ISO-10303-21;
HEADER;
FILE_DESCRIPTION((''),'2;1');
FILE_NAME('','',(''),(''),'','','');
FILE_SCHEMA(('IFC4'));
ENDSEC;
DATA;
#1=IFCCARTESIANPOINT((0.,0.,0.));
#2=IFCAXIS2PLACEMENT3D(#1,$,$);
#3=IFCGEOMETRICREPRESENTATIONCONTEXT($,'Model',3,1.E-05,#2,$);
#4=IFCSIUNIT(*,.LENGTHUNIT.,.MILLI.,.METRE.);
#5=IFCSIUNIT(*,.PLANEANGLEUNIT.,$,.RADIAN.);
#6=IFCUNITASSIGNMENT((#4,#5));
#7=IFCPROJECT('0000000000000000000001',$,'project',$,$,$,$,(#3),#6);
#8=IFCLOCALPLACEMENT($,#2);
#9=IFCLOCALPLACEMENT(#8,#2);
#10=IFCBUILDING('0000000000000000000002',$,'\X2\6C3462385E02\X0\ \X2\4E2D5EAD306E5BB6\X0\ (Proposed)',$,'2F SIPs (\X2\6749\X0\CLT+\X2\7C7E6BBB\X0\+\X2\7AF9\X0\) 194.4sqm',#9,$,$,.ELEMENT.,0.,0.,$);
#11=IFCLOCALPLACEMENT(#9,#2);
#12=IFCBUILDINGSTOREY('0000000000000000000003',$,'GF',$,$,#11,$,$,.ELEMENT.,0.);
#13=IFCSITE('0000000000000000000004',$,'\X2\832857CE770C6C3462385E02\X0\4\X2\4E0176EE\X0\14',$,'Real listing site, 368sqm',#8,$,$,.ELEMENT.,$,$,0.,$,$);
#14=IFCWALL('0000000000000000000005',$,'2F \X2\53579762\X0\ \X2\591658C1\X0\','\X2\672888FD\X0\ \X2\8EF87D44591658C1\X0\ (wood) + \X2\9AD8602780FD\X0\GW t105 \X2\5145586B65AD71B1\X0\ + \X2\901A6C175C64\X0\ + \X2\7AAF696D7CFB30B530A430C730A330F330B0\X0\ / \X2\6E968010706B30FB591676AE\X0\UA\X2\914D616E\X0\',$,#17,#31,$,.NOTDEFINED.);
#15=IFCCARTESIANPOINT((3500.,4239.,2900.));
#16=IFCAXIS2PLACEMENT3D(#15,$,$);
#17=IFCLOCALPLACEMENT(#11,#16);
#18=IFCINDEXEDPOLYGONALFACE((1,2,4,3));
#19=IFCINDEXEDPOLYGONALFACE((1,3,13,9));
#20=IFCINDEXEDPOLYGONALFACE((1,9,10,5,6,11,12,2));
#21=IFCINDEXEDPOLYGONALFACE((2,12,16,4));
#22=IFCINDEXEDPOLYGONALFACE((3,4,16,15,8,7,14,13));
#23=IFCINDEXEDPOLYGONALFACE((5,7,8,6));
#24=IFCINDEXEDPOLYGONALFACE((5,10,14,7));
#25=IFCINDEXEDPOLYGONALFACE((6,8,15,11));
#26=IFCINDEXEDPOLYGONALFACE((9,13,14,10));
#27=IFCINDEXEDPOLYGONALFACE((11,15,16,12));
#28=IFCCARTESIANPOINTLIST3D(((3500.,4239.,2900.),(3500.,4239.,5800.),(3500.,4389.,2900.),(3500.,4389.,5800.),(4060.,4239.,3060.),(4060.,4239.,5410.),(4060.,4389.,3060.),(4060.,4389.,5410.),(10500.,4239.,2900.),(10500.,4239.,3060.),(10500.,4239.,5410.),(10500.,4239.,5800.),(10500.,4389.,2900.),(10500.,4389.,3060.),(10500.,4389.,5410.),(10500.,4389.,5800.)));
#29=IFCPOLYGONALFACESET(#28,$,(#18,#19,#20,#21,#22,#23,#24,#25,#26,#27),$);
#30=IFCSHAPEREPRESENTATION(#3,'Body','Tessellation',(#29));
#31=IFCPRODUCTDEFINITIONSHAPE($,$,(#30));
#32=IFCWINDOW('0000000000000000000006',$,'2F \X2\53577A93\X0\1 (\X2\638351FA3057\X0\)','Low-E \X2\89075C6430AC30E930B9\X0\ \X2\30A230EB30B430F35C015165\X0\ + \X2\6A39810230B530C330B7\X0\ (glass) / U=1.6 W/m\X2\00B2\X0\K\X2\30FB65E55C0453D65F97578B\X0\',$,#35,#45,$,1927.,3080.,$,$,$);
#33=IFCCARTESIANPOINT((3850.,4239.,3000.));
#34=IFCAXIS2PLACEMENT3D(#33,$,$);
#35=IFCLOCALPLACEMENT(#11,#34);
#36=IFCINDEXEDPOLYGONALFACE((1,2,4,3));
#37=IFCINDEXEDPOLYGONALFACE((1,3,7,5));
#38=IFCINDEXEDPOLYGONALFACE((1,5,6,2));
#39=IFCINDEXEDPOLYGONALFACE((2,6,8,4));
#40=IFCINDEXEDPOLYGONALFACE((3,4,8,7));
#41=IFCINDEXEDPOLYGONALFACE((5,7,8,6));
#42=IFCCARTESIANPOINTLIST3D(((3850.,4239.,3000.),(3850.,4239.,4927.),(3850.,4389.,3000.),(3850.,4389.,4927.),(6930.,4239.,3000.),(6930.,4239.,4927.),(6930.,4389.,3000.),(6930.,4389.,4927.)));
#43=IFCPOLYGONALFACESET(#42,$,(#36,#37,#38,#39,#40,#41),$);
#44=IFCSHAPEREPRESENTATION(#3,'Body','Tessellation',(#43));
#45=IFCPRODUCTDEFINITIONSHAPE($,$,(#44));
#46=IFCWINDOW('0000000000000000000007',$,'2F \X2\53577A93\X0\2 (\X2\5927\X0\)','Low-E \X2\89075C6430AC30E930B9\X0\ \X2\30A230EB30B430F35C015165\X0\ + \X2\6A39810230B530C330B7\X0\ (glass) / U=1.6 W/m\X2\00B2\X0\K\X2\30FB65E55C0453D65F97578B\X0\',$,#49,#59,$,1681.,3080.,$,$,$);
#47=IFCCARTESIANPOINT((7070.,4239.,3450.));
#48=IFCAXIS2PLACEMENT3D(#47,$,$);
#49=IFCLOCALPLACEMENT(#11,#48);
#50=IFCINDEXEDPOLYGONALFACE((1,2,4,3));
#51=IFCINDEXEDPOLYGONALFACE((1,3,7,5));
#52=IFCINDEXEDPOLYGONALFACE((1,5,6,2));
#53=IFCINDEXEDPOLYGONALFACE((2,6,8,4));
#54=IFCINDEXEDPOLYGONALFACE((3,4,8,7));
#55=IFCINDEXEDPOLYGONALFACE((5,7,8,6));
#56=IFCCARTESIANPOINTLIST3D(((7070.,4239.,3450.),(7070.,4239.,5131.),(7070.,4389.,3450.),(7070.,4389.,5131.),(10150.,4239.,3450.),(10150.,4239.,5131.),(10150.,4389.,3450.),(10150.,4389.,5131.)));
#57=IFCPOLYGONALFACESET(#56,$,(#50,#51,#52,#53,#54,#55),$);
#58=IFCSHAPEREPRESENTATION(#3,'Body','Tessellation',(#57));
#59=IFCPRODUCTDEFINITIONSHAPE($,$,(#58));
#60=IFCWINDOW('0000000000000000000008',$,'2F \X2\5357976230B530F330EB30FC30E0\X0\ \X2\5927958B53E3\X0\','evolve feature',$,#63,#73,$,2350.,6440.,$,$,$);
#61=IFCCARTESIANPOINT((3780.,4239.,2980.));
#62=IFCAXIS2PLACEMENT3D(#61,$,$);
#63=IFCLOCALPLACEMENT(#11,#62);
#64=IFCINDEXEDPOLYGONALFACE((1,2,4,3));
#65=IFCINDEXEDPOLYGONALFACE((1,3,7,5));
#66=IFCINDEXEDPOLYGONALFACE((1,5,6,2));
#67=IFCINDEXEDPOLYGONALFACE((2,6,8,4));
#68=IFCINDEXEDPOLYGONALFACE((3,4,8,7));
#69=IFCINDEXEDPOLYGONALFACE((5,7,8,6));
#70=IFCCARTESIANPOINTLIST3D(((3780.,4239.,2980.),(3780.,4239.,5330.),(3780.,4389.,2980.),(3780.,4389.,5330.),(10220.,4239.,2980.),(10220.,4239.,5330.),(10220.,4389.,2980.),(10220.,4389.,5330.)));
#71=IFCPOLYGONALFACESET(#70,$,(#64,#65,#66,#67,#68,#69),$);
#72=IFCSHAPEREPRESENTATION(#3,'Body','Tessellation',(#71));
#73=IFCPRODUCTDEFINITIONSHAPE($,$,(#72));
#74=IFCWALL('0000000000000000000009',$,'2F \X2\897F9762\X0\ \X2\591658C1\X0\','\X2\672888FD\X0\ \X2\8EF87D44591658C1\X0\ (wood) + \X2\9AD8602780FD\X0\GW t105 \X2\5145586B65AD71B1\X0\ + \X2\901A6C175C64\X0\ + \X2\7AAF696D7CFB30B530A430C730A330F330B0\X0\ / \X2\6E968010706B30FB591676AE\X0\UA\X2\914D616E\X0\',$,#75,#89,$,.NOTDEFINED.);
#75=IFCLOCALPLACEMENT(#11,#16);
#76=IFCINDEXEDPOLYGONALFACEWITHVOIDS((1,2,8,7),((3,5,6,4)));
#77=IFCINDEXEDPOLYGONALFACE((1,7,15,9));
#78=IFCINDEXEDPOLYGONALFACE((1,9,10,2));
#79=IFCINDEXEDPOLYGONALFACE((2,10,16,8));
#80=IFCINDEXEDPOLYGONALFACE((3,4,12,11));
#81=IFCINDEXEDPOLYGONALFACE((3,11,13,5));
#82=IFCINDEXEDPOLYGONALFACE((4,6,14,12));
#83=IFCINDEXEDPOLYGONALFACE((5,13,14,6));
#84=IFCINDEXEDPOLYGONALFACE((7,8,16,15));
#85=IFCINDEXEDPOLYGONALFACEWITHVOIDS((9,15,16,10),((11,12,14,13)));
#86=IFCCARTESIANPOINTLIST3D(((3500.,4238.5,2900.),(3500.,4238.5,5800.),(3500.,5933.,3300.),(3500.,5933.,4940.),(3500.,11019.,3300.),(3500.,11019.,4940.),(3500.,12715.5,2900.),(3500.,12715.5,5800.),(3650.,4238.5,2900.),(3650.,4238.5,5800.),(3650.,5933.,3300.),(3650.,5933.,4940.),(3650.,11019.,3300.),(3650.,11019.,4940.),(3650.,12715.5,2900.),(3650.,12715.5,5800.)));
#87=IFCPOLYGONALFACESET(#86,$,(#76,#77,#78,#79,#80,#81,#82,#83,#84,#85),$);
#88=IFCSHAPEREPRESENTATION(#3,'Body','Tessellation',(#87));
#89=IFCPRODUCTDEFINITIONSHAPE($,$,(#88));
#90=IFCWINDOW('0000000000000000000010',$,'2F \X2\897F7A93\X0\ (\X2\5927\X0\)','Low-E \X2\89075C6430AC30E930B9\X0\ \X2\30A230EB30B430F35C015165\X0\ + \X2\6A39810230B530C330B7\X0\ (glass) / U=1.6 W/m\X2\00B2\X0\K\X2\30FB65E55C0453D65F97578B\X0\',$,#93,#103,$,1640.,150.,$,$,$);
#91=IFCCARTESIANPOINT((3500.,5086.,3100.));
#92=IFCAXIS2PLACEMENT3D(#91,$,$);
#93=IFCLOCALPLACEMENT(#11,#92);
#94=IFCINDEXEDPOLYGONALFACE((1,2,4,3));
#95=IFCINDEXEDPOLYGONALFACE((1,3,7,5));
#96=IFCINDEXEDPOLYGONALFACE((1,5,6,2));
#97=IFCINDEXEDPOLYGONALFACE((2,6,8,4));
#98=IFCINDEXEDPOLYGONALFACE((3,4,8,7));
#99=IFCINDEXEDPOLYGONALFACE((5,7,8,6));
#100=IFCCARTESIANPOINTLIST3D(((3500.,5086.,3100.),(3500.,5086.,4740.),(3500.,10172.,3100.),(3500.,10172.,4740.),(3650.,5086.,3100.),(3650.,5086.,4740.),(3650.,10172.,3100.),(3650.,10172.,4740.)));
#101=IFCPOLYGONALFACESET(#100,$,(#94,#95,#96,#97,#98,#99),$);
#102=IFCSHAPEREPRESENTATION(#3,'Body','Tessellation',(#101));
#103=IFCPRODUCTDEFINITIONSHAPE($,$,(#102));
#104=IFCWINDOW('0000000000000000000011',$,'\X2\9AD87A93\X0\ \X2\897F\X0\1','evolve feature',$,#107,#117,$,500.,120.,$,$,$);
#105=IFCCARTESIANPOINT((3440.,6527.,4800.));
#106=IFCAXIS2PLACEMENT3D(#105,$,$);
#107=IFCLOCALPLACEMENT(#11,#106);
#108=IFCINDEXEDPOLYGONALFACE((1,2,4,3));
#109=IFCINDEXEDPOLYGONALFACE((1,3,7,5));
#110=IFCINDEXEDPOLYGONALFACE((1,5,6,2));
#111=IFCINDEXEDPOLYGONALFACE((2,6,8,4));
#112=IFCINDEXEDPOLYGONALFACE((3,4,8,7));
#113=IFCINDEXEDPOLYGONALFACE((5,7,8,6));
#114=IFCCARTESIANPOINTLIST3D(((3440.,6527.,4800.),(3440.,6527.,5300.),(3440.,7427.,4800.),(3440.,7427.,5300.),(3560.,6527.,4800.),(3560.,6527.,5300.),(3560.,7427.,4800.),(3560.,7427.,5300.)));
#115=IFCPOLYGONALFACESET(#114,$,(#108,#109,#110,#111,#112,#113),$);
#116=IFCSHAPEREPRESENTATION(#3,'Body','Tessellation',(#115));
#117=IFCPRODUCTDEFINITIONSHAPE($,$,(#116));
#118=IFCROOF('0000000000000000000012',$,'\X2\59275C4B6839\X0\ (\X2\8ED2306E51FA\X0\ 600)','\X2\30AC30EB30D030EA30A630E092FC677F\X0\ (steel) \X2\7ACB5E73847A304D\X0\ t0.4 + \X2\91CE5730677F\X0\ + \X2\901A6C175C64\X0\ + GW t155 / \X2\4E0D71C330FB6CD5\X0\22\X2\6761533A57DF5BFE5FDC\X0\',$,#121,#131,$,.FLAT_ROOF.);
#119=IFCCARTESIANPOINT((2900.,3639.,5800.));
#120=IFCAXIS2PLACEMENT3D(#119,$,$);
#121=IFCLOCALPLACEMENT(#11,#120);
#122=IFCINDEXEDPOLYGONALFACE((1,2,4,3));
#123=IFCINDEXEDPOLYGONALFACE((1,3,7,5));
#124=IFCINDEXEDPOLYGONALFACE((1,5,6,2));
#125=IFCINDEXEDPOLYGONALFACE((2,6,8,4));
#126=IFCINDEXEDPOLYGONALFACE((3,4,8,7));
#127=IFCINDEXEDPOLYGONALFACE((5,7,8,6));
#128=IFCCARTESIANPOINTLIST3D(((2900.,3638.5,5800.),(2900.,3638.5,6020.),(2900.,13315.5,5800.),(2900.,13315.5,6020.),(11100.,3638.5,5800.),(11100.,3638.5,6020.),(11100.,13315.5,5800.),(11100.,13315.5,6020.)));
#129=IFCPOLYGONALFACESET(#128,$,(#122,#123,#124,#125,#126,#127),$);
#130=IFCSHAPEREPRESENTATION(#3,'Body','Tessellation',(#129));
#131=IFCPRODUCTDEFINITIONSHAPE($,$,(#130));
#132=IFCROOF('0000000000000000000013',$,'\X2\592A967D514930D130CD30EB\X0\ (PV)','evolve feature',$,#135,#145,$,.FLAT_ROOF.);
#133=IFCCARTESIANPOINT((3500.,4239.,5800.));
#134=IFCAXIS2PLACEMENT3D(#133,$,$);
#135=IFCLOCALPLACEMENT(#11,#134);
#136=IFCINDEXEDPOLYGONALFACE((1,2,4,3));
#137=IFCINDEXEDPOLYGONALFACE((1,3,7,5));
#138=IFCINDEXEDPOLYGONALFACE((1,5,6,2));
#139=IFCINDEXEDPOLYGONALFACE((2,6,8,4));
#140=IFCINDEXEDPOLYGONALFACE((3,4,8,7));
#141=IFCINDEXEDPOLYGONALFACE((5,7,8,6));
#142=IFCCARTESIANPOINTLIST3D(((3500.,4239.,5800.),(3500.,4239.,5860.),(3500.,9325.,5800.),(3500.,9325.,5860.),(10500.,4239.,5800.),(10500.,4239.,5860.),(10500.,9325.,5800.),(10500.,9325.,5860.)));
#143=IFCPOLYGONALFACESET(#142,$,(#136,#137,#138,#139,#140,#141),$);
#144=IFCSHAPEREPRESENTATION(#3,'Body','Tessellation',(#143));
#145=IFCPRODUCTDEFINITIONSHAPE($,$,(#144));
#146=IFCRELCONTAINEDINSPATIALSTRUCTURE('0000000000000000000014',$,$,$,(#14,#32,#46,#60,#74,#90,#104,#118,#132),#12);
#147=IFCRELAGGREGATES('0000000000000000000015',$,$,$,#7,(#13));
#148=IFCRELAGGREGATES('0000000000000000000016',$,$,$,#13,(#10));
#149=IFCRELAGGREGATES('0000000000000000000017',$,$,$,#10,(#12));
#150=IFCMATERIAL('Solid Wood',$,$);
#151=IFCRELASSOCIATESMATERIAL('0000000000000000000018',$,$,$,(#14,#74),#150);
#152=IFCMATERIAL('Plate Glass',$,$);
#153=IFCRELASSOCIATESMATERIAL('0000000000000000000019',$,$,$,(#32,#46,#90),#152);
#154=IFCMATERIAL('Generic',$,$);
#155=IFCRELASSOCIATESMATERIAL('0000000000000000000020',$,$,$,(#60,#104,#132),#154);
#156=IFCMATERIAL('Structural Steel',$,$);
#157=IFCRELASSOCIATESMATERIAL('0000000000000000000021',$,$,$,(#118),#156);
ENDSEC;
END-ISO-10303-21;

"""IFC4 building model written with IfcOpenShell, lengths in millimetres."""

from ifc_helpers import new_model, si_unit, frame, frame_2d, origin, place, context, project, spatial, rectangle, extrude, material, element, fill, save


model = new_model("IFC4")

# Units and contexts
model_context = context("Model", 3, precision=1e-05, world=origin())
ifc_project = project(units=[si_unit("LENGTHUNIT", "METRE", prefix="MILLI"), si_unit("PLANEANGLEUNIT", "RADIAN")], contexts=[model_context])

# Site, building, storey
site_placement = place(None, origin())
site = spatial("IfcSite", under=ifc_project, at=site_placement, Name="茨城県水戸市4丁目14", ObjectType="Real listing site, 368sqm", CompositionType="ELEMENT", RefElevation=0.0)
building_placement = place(site_placement, origin())
building = spatial("IfcBuilding", under=site, at=building_placement, Name="水戸市 中庭の家 (Proposed)", ObjectType="2F SIPs (杉CLT+籾殻+竹) 194.4sqm", CompositionType="ELEMENT", ElevationOfRefHeight=0.0, ElevationOfTerrain=0.0)
storey_placement = place(building_placement, origin())
storey = spatial("IfcBuildingStorey", under=building, at=storey_placement, Name="GF", CompositionType="ELEMENT", Elevation=0.0)

# Shared definitions
ifc_material_1 = material(Name="Solid Wood")
ifc_material_2 = material(Name="Generic")

# Shared definitions
ifc_material_3 = material(Name="Plate Glass")

# Walls, openings, windows
wall_1_placement = place(storey_placement, frame((3500.0, 4239.0, 2900.0)))
wall_1 = element("IfcWall", 1, at=wall_1_placement, inside=storey, material=ifc_material_1, Name="2F 南面 外壁", Description="木製 軸組外壁 (wood) + 高性能GW t105 充填断熱 + 通気層 + 窯業系サイディング / 準耐火・外皮UA配慮", PredefinedType="NOTDEFINED", context=model_context, shape_type="SweptSolid", body=[
    extrude(rectangle(XDim=7000.0, YDim=150.0, at=frame_2d((3500.0, 75.0))), frame((3500.0, 4239.0, 2900.0)), (0.0, 0.0, 1.0), 2900.0),
])
opening_1_placement = place(storey_placement, frame((3850.0, 4239.0, 3000.0)))
opening_1 = element("IfcOpeningElement", 2, at=opening_1_placement, cuts=wall_1, PredefinedType="NOTDEFINED", context=model_context, shape_type="SweptSolid", body=[
    extrude(rectangle(XDim=3080.0, YDim=150.0, at=frame_2d((1540.0, 75.0))), frame((3850.0, 4239.0, 3000.0)), (0.0, 0.0, 1.0), 1927.0),
])
opening_2_placement = place(storey_placement, frame((7070.0, 4239.0, 3450.0)))
opening_2 = element("IfcOpeningElement", 3, at=opening_2_placement, cuts=wall_1, PredefinedType="NOTDEFINED", context=model_context, shape_type="SweptSolid", body=[
    extrude(rectangle(XDim=3080.0, YDim=150.0, at=frame_2d((1540.0, 75.0))), frame((7070.0, 4239.0, 3450.0)), (0.0, 0.0, 1.0), 1681.0),
])
opening_3_placement = place(storey_placement, frame((3780.0, 4239.0, 2980.0)))
opening_3 = element("IfcOpeningElement", 4, at=opening_3_placement, cuts=wall_1, PredefinedType="NOTDEFINED", context=model_context, shape_type="SweptSolid", body=[
    extrude(rectangle(XDim=6440.0, YDim=150.0, at=frame_2d((3220.0, 75.0))), frame((3780.0, 4239.0, 2980.0)), (0.0, 0.0, 1.0), 2350.0),
])
window_1_placement = place(storey_placement, frame((3850.0, 4239.0, 3000.0)))
window_1 = element("IfcWindow", 5, at=window_1_placement, inside=storey, material=ifc_material_3, Name="2F 南窓1 (掃出し)", Description="Low-E 複層ガラス アルゴン封入 + 樹脂サッシ (glass) / U=1.6 W/m²K・日射取得型", OverallHeight=1927.0, OverallWidth=3080.0, context=model_context, shape_type="SweptSolid", body=[
    extrude(rectangle(XDim=3080.0, YDim=150.0, at=frame_2d((1540.0, 75.0))), frame((3850.0, 4239.0, 3000.0)), (0.0, 0.0, 1.0), 1927.0),
])
fill(opening_1, window_1)
window_2_placement = place(storey_placement, frame((7070.0, 4239.0, 3450.0)))
window_2 = element("IfcWindow", 6, at=window_2_placement, inside=storey, material=ifc_material_3, Name="2F 南窓2 (大)", Description="Low-E 複層ガラス アルゴン封入 + 樹脂サッシ (glass) / U=1.6 W/m²K・日射取得型", OverallHeight=1681.0, OverallWidth=3080.0, context=model_context, shape_type="SweptSolid", body=[
    extrude(rectangle(XDim=3080.0, YDim=150.0, at=frame_2d((1540.0, 75.0))), frame((7070.0, 4239.0, 3450.0)), (0.0, 0.0, 1.0), 1681.0),
])
fill(opening_2, window_2)
window_3_placement = place(storey_placement, frame((3780.0, 4239.0, 2980.0)))
window_3 = element("IfcWindow", 7, at=window_3_placement, inside=storey, material=ifc_material_2, Name="2F 南面サンルーム 大開口", Description="evolve feature", OverallHeight=2350.0, OverallWidth=6440.0, context=model_context, shape_type="SweptSolid", body=[
    extrude(rectangle(XDim=6440.0, YDim=150.0, at=frame_2d((3220.0, 75.0))), frame((3780.0, 4239.0, 2980.0)), (0.0, 0.0, 1.0), 2350.0),
])
fill(opening_3, window_3)
wall_2_placement = place(storey_placement, frame((3500.0, 4239.0, 2900.0)))
wall_2 = element("IfcWall", 8, at=wall_2_placement, inside=storey, material=ifc_material_1, Name="2F 西面 外壁", Description="木製 軸組外壁 (wood) + 高性能GW t105 充填断熱 + 通気層 + 窯業系サイディング / 準耐火・外皮UA配慮", PredefinedType="NOTDEFINED", context=model_context, shape_type="SweptSolid", body=[
    extrude(rectangle(XDim=150.0, YDim=8477.0, at=frame_2d((75.0, 4238.0))), frame((3500.0, 4239.0, 2900.0)), (0.0, 0.0, 1.0), 2900.0),
])
opening_4_placement = place(storey_placement, frame((3500.0, 5086.0, 3100.0)))
opening_4 = element("IfcOpeningElement", 9, at=opening_4_placement, cuts=wall_2, PredefinedType="NOTDEFINED", context=model_context, shape_type="SweptSolid", body=[
    extrude(rectangle(XDim=150.0, YDim=5086.0, at=frame_2d((75.0, 2543.0))), frame((3500.0, 5086.0, 3100.0)), (0.0, 0.0, 1.0), 1640.0),
])
opening_5_placement = place(storey_placement, frame((3440.0, 6527.0, 4800.0)))
opening_5 = element("IfcOpeningElement", 10, at=opening_5_placement, cuts=wall_2, PredefinedType="NOTDEFINED", context=model_context, shape_type="SweptSolid", body=[
    extrude(rectangle(XDim=120.0, YDim=900.0, at=frame_2d((60.0, 450.0))), frame((3440.0, 6527.0, 4800.0)), (0.0, 0.0, 1.0), 500.0),
])
window_4_placement = place(storey_placement, frame((3500.0, 5086.0, 3100.0)))
window_4 = element("IfcWindow", 11, at=window_4_placement, inside=storey, material=ifc_material_3, Name="2F 西窓 (大)", Description="Low-E 複層ガラス アルゴン封入 + 樹脂サッシ (glass) / U=1.6 W/m²K・日射取得型", OverallHeight=1640.0, OverallWidth=150.0, context=model_context, shape_type="SweptSolid", body=[
    extrude(rectangle(XDim=150.0, YDim=5086.0, at=frame_2d((75.0, 2543.0))), frame((3500.0, 5086.0, 3100.0)), (0.0, 0.0, 1.0), 1640.0),
])
fill(opening_4, window_4)
window_5_placement = place(storey_placement, frame((3440.0, 6527.0, 4800.0)))
window_5 = element("IfcWindow", 12, at=window_5_placement, inside=storey, material=ifc_material_2, Name="高窓 西1", Description="evolve feature", OverallHeight=500.0, OverallWidth=120.0, context=model_context, shape_type="SweptSolid", body=[
    extrude(rectangle(XDim=120.0, YDim=900.0, at=frame_2d((60.0, 450.0))), frame((3440.0, 6527.0, 4800.0)), (0.0, 0.0, 1.0), 500.0),
])
fill(opening_5, window_5)

# Roofs
ifc_material_4 = material(Name="Structural Steel")
roof_1_placement = place(storey_placement, frame((2900.0, 3639.0, 5800.0)))
element("IfcRoof", 13, at=roof_1_placement, inside=storey, material=ifc_material_4, Name="大屋根 (軒の出 600)", Description="ガルバリウム鋼板 (steel) 立平葺き t0.4 + 野地板 + 通気層 + GW t155 / 不燃・法22条区域対応", PredefinedType="FLAT_ROOF", context=model_context, shape_type="SweptSolid", body=[
    extrude(rectangle(XDim=8200.0, YDim=9677.0, at=frame_2d((4100.0, 4838.0))), frame((2900.0, 3639.0, 5800.0)), (0.0, 0.0, 1.0), 220.0),
])
roof_2_placement = place(storey_placement, frame((3500.0, 4239.0, 5800.0)))
element("IfcRoof", 14, at=roof_2_placement, inside=storey, material=ifc_material_2, Name="太陽光パネル (PV)", Description="evolve feature", PredefinedType="FLAT_ROOF", context=model_context, shape_type="SweptSolid", body=[
    extrude(rectangle(XDim=7000.0, YDim=5086.0, at=frame_2d((3500.0, 2543.0))), frame((3500.0, 4239.0, 5800.0)), (0.0, 0.0, 1.0), 60.0),
])

save(model, "model.ifc")
